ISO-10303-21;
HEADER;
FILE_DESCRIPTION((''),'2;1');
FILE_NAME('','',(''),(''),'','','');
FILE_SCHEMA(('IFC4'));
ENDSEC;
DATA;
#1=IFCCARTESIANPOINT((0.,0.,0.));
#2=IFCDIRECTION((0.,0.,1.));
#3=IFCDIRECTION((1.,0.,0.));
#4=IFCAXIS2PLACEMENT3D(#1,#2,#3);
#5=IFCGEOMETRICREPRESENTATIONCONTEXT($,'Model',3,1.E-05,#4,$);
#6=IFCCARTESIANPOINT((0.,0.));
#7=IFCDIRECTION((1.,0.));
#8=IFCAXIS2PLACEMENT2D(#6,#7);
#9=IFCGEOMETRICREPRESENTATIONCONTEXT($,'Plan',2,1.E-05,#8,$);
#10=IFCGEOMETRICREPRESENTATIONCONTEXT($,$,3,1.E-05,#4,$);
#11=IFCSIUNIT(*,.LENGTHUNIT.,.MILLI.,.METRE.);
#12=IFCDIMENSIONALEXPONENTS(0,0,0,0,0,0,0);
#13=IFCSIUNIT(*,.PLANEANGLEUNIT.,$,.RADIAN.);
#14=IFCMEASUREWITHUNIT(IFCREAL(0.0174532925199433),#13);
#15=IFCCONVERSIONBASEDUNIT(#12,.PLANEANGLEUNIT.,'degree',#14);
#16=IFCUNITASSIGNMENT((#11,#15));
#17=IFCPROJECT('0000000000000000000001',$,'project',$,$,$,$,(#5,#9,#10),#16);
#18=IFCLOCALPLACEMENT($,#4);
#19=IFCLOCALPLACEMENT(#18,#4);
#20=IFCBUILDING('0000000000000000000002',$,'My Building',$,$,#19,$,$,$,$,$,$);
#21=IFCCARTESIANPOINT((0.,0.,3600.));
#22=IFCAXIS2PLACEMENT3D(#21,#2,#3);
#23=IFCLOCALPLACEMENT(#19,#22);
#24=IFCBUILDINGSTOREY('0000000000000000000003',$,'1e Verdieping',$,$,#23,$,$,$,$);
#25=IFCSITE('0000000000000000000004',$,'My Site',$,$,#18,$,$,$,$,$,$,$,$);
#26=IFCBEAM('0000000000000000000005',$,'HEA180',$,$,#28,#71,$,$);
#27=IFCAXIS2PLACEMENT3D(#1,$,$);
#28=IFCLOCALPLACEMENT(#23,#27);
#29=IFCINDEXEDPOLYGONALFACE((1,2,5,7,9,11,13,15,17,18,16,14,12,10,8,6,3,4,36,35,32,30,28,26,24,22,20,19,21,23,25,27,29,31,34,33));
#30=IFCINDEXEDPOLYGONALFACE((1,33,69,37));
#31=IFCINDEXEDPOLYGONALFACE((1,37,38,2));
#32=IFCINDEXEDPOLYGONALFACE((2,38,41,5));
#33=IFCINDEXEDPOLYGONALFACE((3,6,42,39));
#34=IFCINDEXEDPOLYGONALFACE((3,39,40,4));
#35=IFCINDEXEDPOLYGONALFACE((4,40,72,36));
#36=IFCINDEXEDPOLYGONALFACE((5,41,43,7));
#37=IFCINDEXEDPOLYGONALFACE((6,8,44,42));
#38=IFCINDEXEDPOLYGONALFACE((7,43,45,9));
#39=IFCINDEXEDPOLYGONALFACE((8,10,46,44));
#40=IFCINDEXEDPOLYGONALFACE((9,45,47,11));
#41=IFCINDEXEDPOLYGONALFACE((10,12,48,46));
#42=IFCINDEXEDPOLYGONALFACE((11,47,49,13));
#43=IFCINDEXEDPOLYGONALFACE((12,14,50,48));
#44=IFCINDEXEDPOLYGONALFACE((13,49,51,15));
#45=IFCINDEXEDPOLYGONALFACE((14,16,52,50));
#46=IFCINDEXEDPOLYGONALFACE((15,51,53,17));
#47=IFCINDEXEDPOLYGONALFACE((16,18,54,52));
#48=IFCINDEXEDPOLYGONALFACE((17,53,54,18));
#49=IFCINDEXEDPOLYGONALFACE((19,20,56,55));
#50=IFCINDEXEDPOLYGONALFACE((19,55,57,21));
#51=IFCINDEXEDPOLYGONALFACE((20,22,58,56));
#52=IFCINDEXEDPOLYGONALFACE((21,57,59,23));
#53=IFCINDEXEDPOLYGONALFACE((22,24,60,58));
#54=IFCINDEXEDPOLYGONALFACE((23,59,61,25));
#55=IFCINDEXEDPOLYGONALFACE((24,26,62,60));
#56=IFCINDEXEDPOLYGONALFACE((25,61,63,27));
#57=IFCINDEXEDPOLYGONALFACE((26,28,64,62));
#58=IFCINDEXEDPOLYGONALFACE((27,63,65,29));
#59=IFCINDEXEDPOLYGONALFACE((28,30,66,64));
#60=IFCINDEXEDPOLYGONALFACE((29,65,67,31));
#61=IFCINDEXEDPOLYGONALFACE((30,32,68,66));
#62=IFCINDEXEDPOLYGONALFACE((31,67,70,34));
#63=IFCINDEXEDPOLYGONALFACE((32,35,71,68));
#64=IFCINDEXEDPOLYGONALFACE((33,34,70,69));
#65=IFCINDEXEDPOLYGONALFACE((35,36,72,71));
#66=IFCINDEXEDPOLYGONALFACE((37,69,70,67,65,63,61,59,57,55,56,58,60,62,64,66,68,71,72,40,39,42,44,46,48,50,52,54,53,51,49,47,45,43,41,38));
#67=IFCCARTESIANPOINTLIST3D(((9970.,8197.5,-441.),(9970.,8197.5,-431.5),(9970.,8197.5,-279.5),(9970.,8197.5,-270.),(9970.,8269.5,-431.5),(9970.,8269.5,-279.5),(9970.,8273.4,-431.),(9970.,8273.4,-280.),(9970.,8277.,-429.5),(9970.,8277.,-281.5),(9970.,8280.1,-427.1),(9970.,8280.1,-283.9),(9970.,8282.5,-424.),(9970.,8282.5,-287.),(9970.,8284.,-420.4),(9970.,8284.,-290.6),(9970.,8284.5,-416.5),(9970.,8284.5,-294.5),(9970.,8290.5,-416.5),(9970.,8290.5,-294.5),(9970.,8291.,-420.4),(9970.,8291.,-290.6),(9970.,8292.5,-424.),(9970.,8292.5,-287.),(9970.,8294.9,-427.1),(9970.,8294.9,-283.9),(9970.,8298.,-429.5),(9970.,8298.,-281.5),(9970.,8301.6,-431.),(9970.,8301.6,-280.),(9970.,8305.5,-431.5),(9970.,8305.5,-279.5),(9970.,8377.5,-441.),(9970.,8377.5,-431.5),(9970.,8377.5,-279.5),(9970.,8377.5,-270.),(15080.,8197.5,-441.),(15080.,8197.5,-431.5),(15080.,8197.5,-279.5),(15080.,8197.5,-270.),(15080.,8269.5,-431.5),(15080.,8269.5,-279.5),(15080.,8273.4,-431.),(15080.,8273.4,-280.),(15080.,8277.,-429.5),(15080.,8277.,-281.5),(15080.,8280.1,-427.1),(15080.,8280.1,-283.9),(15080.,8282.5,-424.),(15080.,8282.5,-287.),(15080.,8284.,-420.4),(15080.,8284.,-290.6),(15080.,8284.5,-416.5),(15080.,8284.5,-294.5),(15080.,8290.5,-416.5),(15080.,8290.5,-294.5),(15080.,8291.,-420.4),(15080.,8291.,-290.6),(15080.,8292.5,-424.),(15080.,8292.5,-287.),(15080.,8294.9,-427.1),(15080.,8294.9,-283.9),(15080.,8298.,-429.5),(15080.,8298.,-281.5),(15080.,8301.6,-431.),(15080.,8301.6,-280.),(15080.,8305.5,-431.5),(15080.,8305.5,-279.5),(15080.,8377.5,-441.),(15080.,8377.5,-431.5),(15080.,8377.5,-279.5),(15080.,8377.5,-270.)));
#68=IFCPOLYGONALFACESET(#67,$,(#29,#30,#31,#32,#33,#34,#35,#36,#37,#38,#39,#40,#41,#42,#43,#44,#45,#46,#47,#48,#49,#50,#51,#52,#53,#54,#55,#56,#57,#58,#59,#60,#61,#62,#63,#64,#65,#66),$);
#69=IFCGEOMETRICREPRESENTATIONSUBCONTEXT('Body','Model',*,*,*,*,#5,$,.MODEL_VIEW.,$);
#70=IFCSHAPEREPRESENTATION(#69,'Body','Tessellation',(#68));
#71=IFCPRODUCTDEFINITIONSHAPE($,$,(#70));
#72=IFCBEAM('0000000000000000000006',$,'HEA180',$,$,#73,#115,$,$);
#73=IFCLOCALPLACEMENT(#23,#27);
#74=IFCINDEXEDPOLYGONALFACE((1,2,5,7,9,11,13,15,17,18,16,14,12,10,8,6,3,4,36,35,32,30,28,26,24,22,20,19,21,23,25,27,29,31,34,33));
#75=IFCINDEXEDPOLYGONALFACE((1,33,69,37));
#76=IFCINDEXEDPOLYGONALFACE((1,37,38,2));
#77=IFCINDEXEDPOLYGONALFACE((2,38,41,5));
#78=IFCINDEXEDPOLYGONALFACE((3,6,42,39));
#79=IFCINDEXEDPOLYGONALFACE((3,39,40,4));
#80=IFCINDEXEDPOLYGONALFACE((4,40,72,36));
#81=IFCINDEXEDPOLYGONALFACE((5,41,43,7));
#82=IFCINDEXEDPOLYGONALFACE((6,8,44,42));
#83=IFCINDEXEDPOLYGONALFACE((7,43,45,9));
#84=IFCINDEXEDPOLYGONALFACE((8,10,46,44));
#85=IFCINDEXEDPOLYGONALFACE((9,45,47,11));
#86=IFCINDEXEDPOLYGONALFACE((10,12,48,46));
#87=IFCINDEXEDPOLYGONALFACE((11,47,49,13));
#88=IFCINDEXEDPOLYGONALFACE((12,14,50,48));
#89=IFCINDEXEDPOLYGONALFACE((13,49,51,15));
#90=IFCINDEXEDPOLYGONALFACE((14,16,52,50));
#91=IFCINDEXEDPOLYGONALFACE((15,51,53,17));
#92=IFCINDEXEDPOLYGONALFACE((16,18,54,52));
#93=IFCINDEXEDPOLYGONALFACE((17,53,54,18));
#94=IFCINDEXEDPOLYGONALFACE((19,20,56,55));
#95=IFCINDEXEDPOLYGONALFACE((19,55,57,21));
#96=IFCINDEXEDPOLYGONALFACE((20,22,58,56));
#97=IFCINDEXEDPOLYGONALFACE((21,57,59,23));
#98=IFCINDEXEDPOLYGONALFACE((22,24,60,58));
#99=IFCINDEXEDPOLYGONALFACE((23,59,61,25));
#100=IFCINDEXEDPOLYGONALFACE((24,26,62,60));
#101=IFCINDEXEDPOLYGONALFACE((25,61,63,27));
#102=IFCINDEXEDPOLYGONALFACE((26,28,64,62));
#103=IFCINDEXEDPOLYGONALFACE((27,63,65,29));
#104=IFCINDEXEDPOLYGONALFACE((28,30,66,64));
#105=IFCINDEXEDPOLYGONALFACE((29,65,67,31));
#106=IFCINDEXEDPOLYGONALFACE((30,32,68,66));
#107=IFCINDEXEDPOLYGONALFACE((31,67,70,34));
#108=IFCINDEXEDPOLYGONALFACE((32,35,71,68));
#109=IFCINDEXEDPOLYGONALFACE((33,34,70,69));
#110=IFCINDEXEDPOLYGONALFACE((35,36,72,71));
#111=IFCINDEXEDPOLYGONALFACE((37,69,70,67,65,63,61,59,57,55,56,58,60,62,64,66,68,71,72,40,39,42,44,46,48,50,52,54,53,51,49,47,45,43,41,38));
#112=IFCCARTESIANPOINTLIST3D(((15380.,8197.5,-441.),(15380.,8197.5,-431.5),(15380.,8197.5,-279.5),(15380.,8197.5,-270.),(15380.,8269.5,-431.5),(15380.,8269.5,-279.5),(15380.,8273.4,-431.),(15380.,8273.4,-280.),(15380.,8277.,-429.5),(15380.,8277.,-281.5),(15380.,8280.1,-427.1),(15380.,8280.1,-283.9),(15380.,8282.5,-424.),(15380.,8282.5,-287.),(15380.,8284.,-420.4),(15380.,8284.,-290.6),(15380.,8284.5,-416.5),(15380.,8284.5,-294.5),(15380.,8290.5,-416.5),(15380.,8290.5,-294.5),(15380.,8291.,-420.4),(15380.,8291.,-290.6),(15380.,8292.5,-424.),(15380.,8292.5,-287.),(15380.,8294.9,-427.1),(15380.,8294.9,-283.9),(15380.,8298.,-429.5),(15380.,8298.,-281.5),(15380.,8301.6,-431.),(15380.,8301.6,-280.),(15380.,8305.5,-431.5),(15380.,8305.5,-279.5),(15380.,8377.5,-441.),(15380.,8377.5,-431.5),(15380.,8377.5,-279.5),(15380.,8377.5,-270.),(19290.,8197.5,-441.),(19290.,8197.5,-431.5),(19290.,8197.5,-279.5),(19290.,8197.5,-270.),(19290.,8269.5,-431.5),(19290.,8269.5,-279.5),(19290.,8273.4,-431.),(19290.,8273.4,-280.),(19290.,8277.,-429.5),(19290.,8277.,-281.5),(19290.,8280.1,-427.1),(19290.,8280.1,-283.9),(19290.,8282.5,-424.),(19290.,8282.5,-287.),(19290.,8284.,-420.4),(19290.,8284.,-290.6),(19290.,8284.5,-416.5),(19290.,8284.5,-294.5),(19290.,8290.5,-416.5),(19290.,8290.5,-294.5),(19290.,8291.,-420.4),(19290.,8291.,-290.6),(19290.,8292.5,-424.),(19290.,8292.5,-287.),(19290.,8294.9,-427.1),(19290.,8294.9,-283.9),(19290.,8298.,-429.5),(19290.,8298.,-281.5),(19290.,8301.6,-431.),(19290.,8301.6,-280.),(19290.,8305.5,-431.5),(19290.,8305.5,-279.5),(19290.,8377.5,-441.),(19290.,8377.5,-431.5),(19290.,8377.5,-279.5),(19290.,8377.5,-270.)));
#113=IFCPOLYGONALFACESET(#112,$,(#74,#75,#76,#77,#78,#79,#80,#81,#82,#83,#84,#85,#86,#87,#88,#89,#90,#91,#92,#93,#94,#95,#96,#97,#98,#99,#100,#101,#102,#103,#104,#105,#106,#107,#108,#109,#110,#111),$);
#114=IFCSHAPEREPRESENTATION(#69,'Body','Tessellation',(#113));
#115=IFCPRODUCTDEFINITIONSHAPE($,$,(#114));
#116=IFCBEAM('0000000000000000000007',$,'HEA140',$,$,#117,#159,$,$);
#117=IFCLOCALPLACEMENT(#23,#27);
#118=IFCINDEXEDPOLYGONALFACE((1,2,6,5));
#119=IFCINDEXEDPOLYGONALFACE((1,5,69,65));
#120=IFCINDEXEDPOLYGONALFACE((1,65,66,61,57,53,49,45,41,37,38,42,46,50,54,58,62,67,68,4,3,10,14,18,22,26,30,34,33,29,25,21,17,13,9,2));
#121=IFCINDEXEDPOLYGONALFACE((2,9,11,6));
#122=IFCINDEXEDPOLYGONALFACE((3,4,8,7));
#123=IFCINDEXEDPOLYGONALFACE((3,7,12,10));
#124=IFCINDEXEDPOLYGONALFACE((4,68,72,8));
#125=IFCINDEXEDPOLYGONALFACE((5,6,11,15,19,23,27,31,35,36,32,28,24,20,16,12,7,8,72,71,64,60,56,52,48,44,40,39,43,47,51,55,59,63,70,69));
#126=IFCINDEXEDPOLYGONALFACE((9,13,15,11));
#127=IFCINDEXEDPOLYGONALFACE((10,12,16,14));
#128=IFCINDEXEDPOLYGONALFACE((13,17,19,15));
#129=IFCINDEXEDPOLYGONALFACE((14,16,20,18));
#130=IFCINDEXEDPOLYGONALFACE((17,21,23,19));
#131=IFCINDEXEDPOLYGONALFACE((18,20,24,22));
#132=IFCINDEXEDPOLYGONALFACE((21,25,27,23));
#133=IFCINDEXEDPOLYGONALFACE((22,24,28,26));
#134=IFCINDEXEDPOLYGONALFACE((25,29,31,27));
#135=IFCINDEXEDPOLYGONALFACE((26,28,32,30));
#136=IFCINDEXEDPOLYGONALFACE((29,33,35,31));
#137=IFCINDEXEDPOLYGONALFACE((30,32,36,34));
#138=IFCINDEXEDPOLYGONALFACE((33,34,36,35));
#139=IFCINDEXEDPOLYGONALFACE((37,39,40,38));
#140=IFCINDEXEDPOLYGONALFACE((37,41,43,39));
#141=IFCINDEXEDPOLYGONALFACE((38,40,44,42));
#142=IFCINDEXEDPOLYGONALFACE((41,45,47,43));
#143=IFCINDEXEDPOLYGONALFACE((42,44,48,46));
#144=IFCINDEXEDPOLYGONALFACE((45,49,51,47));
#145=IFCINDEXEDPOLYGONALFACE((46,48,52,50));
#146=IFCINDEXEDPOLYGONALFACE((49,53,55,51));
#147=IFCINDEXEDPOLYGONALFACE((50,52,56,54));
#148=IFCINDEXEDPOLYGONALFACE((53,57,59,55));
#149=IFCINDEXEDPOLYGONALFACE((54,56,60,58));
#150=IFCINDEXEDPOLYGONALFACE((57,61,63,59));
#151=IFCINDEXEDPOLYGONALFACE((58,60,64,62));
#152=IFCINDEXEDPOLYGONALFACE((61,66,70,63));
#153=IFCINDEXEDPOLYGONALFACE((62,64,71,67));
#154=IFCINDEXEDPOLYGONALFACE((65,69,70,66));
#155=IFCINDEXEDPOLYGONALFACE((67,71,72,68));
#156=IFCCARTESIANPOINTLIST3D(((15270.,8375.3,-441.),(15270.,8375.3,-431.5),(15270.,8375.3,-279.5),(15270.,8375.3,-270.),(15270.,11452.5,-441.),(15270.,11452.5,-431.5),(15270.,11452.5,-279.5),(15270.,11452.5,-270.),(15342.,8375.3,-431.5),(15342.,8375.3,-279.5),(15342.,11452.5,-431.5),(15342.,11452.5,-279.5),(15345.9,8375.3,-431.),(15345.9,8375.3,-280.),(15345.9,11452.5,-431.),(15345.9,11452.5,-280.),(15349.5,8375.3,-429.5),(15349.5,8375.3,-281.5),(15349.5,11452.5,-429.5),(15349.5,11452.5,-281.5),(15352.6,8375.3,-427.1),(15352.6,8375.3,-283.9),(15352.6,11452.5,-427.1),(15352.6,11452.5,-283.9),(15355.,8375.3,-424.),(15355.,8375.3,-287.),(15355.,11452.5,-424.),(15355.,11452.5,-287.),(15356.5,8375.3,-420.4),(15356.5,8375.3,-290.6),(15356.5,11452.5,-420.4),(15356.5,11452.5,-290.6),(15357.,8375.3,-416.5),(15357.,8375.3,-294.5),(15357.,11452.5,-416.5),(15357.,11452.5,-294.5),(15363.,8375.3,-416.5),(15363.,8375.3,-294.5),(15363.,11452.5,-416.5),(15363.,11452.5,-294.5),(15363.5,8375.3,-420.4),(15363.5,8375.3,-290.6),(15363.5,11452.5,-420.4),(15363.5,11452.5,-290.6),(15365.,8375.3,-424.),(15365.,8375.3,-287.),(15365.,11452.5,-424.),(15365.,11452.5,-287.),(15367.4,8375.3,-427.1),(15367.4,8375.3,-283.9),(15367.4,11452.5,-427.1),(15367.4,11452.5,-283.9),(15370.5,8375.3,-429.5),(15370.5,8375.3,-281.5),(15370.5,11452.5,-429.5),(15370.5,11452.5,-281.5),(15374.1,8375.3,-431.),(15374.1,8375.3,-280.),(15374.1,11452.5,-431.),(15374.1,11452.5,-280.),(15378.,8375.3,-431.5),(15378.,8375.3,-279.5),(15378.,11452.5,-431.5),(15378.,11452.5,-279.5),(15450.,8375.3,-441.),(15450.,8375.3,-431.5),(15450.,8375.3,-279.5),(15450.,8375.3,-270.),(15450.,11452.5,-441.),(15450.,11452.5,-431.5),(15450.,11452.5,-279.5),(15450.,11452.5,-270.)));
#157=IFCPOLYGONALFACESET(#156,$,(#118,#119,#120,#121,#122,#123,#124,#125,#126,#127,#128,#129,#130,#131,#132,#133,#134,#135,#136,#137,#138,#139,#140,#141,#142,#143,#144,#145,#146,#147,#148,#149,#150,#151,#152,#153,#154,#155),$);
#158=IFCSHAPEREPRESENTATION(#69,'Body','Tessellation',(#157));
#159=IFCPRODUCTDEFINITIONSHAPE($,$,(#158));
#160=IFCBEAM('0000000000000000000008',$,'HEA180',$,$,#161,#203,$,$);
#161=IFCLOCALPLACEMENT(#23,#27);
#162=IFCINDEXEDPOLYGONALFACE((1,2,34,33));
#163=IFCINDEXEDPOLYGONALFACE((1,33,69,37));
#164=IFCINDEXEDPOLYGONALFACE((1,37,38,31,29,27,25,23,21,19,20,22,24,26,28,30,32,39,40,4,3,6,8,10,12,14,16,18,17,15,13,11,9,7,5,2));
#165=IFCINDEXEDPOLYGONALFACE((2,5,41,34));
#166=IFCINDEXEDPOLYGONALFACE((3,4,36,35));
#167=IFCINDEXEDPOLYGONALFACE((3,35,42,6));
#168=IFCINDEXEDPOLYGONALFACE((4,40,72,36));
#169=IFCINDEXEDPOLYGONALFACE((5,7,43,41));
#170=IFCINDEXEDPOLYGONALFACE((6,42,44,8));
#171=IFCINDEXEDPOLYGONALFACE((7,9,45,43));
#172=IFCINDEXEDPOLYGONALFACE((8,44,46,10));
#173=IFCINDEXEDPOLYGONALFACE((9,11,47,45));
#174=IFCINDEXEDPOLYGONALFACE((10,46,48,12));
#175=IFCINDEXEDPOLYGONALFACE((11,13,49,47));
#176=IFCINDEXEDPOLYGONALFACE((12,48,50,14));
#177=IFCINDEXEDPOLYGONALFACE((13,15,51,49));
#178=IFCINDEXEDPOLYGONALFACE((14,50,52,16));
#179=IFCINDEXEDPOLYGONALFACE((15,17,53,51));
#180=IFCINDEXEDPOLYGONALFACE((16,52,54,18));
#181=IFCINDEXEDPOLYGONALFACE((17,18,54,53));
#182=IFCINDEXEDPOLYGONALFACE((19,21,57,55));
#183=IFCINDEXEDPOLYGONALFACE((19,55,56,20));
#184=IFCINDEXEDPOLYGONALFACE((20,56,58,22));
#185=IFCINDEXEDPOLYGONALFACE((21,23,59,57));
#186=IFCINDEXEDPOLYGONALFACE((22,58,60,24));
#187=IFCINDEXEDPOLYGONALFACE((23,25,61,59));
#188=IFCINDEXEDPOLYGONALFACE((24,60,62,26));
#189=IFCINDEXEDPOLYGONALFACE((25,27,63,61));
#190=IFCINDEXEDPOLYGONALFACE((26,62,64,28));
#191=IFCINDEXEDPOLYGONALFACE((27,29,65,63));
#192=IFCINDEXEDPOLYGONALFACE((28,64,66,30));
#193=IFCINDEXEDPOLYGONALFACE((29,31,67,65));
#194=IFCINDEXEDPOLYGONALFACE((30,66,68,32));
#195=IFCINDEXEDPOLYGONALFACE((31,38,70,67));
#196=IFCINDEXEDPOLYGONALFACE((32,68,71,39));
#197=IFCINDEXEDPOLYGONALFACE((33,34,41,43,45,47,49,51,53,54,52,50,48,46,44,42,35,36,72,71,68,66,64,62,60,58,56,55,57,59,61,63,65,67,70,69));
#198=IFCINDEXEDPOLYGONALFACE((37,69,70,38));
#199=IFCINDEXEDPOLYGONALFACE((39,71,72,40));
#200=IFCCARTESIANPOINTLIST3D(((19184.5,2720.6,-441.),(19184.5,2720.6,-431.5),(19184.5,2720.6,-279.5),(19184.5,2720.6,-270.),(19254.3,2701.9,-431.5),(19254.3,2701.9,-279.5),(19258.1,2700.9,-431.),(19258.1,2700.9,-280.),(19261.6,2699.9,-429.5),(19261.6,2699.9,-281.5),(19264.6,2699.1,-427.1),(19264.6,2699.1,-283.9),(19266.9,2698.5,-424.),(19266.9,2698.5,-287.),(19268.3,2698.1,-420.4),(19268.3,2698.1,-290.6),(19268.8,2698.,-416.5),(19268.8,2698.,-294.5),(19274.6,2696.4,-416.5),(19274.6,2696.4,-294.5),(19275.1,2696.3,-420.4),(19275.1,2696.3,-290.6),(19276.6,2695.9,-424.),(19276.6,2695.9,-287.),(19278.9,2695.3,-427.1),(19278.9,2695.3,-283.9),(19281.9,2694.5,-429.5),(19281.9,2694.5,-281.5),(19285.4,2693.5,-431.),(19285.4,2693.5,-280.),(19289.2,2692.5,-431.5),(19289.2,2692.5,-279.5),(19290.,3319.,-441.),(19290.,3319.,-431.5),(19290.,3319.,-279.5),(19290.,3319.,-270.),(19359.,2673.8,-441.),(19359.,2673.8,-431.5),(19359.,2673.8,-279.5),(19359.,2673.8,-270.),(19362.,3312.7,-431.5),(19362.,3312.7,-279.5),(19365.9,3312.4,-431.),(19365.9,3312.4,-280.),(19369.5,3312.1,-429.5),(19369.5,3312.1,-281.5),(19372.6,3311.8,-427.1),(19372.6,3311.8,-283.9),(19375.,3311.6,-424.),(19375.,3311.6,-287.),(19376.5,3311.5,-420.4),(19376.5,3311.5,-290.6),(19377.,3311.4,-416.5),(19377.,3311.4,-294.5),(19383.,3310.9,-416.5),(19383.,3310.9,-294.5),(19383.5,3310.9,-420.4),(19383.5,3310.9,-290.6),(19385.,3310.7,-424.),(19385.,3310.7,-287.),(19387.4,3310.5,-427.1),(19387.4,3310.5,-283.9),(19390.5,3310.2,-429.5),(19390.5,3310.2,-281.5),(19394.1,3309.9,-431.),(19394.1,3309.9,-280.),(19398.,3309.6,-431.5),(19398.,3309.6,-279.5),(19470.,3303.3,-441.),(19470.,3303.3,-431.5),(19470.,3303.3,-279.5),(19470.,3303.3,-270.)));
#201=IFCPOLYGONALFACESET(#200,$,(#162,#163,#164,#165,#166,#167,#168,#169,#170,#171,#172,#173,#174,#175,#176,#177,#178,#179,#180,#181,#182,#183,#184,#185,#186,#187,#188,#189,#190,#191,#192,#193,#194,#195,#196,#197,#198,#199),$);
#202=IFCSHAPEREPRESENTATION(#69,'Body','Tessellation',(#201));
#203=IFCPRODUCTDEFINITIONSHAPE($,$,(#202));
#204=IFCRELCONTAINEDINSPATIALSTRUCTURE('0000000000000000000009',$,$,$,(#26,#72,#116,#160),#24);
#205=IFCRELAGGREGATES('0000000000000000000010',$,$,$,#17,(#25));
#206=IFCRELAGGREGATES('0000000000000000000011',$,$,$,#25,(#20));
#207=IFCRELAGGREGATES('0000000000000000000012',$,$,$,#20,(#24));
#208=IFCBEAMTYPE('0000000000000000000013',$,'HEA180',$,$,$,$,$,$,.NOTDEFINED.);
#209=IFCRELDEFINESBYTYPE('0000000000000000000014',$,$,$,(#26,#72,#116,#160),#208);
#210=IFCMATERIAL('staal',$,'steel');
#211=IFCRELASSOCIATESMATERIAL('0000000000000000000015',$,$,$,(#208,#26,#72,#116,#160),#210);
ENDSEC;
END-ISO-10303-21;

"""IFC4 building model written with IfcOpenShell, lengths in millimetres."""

from ifc_helpers import new_model, entity, si_unit, converted_unit, frame, origin_with_axes, origin_2d_with_axis, place, context, subcontext, project, spatial, i_section, extrude, clip, halfspace, material, material_profile, profile_set, profile_usage, type_object, element, save


model = new_model("IFC4")

# Units and contexts
model_context = context("Model", 3, precision=1e-05, world=origin_with_axes())
plan_context = context("Plan", 2, precision=1e-05, world=origin_2d_with_axis())
context_of_model = context(None, 3, precision=1e-05, world=origin_with_axes())
body_context = subcontext(model_context, "Body", "Model", "MODEL_VIEW")
ifc_project = project(units=[si_unit("LENGTHUNIT", "METRE", prefix="MILLI"), converted_unit("PLANEANGLEUNIT", "degree", entity("IfcReal", 0.0174532925199433), si_unit("PLANEANGLEUNIT", "RADIAN"), dimensions=[0, 0, 0, 0, 0, 0, 0])], contexts=[model_context, plan_context, context_of_model])

# Site, building, storey
site_placement = place(None, origin_with_axes())
site = spatial("IfcSite", under=ifc_project, at=site_placement, Name="My Site")
building_placement = place(site_placement, origin_with_axes())
building = spatial("IfcBuilding", under=site, at=building_placement, Name="My Building")
storey_placement = place(building_placement, frame((0.0, 0.0, 3600.0), z_axis=(0.0, 0.0, 1.0), x_axis=(1.0, 0.0, 0.0)))
storey = spatial("IfcBuildingStorey", under=building, at=storey_placement, Name="1e Verdieping")

# Shared definitions
ifc_material = material(Name="staal", Category="steel")

# Beams
ifc_material_profile_1 = material_profile(ifc_material, i_section(OverallWidth=180.0, OverallDepth=171.0, WebThickness=6.0, FlangeThickness=9.5, FilletRadius=15.0))
ifc_profile_set_1 = profile_set([ifc_material_profile_1], Name="HEA180")
ifc_profile_usage_1 = profile_usage(ifc_profile_set_1)
beam_type_1 = type_object("IfcBeamType", Name="HEA180", PredefinedType="NOTDEFINED", material=ifc_profile_set_1)
beam_1_placement = place(storey_placement, frame((9970.0, 8287.5, -355.5), z_axis=(1.0, 0.0, 0.0), x_axis=(0.0, 1.0, 0.0)))
element("IfcBeam", 1, at=beam_1_placement, inside=storey, type_object=beam_type_1, material=ifc_profile_usage_1, Name="HEA180", context=body_context, shape_type="SweptSolid", body=[
    extrude(i_section(OverallWidth=180.0, OverallDepth=171.0, WebThickness=6.0, FlangeThickness=9.5, FilletRadius=15.0), origin_with_axes(), (0.0, 0.0, 1.0), 5110.0),
])
ifc_profile_usage_2 = profile_usage(ifc_profile_set_1)
beam_2_placement = place(storey_placement, frame((15380.0, 8287.5, -355.5), z_axis=(1.0, 0.0, 0.0), x_axis=(0.0, 1.0, 0.0)))
element("IfcBeam", 2, at=beam_2_placement, inside=storey, type_object=beam_type_1, material=ifc_profile_usage_2, Name="HEA180", context=body_context, shape_type="SweptSolid", body=[
    extrude(i_section(OverallWidth=180.0, OverallDepth=171.0, WebThickness=6.0, FlangeThickness=9.5, FilletRadius=15.0), origin_with_axes(), (0.0, 0.0, 1.0), 3910.0),
])
ifc_profile_usage_3 = profile_usage(ifc_profile_set_1)
beam_3_placement = place(storey_placement, frame((15360.0, 8375.3, -355.5), z_axis=(0.0, 1.0, 0.0), x_axis=(-1.0, 0.0, 0.0)))
element("IfcBeam", 3, at=beam_3_placement, inside=storey, type_object=beam_type_1, material=ifc_profile_usage_3, Name="HEA140", context=body_context, shape_type="SweptSolid", body=[
    extrude(i_section(OverallWidth=180.0, OverallDepth=171.0, WebThickness=6.0, FlangeThickness=9.5, FilletRadius=15.0), origin_with_axes(), (0.0, 0.0, 1.0), 3077.2),
])
ifc_profile_usage_4 = profile_usage(ifc_profile_set_1)
beam_4_placement = place(storey_placement, frame((19501.3, 3998.8, -355.5), z_axis=(-0.173648, -0.984808, 0.0), x_axis=(0.984808, -0.173648, 0.0)))
element("IfcBeam", 4, at=beam_4_placement, inside=storey, type_object=beam_type_1, material=ifc_profile_usage_4, Name="HEA180", context=body_context, shape_type="Clipping", body=[
    clip(clip(extrude(i_section(OverallWidth=180.0, OverallDepth=171.0, WebThickness=6.0, FlangeThickness=9.5, FilletRadius=15.0), origin_with_axes(), (0.0, 0.0, 1.0), 2020.0), halfspace(frame((90.0, -3244.5, 690.4), z_axis=(-0.087187, 0.0, -0.996192), x_axis=(-0.000001, 1.0, 0.0)), False)), halfspace(frame((90.0, -3244.5, 1329.6), z_axis=(-0.087174, 0.0, 0.996193), x_axis=(0.0, 1.0, 0.0)), False)),
])

save(model, "model.ifc")
